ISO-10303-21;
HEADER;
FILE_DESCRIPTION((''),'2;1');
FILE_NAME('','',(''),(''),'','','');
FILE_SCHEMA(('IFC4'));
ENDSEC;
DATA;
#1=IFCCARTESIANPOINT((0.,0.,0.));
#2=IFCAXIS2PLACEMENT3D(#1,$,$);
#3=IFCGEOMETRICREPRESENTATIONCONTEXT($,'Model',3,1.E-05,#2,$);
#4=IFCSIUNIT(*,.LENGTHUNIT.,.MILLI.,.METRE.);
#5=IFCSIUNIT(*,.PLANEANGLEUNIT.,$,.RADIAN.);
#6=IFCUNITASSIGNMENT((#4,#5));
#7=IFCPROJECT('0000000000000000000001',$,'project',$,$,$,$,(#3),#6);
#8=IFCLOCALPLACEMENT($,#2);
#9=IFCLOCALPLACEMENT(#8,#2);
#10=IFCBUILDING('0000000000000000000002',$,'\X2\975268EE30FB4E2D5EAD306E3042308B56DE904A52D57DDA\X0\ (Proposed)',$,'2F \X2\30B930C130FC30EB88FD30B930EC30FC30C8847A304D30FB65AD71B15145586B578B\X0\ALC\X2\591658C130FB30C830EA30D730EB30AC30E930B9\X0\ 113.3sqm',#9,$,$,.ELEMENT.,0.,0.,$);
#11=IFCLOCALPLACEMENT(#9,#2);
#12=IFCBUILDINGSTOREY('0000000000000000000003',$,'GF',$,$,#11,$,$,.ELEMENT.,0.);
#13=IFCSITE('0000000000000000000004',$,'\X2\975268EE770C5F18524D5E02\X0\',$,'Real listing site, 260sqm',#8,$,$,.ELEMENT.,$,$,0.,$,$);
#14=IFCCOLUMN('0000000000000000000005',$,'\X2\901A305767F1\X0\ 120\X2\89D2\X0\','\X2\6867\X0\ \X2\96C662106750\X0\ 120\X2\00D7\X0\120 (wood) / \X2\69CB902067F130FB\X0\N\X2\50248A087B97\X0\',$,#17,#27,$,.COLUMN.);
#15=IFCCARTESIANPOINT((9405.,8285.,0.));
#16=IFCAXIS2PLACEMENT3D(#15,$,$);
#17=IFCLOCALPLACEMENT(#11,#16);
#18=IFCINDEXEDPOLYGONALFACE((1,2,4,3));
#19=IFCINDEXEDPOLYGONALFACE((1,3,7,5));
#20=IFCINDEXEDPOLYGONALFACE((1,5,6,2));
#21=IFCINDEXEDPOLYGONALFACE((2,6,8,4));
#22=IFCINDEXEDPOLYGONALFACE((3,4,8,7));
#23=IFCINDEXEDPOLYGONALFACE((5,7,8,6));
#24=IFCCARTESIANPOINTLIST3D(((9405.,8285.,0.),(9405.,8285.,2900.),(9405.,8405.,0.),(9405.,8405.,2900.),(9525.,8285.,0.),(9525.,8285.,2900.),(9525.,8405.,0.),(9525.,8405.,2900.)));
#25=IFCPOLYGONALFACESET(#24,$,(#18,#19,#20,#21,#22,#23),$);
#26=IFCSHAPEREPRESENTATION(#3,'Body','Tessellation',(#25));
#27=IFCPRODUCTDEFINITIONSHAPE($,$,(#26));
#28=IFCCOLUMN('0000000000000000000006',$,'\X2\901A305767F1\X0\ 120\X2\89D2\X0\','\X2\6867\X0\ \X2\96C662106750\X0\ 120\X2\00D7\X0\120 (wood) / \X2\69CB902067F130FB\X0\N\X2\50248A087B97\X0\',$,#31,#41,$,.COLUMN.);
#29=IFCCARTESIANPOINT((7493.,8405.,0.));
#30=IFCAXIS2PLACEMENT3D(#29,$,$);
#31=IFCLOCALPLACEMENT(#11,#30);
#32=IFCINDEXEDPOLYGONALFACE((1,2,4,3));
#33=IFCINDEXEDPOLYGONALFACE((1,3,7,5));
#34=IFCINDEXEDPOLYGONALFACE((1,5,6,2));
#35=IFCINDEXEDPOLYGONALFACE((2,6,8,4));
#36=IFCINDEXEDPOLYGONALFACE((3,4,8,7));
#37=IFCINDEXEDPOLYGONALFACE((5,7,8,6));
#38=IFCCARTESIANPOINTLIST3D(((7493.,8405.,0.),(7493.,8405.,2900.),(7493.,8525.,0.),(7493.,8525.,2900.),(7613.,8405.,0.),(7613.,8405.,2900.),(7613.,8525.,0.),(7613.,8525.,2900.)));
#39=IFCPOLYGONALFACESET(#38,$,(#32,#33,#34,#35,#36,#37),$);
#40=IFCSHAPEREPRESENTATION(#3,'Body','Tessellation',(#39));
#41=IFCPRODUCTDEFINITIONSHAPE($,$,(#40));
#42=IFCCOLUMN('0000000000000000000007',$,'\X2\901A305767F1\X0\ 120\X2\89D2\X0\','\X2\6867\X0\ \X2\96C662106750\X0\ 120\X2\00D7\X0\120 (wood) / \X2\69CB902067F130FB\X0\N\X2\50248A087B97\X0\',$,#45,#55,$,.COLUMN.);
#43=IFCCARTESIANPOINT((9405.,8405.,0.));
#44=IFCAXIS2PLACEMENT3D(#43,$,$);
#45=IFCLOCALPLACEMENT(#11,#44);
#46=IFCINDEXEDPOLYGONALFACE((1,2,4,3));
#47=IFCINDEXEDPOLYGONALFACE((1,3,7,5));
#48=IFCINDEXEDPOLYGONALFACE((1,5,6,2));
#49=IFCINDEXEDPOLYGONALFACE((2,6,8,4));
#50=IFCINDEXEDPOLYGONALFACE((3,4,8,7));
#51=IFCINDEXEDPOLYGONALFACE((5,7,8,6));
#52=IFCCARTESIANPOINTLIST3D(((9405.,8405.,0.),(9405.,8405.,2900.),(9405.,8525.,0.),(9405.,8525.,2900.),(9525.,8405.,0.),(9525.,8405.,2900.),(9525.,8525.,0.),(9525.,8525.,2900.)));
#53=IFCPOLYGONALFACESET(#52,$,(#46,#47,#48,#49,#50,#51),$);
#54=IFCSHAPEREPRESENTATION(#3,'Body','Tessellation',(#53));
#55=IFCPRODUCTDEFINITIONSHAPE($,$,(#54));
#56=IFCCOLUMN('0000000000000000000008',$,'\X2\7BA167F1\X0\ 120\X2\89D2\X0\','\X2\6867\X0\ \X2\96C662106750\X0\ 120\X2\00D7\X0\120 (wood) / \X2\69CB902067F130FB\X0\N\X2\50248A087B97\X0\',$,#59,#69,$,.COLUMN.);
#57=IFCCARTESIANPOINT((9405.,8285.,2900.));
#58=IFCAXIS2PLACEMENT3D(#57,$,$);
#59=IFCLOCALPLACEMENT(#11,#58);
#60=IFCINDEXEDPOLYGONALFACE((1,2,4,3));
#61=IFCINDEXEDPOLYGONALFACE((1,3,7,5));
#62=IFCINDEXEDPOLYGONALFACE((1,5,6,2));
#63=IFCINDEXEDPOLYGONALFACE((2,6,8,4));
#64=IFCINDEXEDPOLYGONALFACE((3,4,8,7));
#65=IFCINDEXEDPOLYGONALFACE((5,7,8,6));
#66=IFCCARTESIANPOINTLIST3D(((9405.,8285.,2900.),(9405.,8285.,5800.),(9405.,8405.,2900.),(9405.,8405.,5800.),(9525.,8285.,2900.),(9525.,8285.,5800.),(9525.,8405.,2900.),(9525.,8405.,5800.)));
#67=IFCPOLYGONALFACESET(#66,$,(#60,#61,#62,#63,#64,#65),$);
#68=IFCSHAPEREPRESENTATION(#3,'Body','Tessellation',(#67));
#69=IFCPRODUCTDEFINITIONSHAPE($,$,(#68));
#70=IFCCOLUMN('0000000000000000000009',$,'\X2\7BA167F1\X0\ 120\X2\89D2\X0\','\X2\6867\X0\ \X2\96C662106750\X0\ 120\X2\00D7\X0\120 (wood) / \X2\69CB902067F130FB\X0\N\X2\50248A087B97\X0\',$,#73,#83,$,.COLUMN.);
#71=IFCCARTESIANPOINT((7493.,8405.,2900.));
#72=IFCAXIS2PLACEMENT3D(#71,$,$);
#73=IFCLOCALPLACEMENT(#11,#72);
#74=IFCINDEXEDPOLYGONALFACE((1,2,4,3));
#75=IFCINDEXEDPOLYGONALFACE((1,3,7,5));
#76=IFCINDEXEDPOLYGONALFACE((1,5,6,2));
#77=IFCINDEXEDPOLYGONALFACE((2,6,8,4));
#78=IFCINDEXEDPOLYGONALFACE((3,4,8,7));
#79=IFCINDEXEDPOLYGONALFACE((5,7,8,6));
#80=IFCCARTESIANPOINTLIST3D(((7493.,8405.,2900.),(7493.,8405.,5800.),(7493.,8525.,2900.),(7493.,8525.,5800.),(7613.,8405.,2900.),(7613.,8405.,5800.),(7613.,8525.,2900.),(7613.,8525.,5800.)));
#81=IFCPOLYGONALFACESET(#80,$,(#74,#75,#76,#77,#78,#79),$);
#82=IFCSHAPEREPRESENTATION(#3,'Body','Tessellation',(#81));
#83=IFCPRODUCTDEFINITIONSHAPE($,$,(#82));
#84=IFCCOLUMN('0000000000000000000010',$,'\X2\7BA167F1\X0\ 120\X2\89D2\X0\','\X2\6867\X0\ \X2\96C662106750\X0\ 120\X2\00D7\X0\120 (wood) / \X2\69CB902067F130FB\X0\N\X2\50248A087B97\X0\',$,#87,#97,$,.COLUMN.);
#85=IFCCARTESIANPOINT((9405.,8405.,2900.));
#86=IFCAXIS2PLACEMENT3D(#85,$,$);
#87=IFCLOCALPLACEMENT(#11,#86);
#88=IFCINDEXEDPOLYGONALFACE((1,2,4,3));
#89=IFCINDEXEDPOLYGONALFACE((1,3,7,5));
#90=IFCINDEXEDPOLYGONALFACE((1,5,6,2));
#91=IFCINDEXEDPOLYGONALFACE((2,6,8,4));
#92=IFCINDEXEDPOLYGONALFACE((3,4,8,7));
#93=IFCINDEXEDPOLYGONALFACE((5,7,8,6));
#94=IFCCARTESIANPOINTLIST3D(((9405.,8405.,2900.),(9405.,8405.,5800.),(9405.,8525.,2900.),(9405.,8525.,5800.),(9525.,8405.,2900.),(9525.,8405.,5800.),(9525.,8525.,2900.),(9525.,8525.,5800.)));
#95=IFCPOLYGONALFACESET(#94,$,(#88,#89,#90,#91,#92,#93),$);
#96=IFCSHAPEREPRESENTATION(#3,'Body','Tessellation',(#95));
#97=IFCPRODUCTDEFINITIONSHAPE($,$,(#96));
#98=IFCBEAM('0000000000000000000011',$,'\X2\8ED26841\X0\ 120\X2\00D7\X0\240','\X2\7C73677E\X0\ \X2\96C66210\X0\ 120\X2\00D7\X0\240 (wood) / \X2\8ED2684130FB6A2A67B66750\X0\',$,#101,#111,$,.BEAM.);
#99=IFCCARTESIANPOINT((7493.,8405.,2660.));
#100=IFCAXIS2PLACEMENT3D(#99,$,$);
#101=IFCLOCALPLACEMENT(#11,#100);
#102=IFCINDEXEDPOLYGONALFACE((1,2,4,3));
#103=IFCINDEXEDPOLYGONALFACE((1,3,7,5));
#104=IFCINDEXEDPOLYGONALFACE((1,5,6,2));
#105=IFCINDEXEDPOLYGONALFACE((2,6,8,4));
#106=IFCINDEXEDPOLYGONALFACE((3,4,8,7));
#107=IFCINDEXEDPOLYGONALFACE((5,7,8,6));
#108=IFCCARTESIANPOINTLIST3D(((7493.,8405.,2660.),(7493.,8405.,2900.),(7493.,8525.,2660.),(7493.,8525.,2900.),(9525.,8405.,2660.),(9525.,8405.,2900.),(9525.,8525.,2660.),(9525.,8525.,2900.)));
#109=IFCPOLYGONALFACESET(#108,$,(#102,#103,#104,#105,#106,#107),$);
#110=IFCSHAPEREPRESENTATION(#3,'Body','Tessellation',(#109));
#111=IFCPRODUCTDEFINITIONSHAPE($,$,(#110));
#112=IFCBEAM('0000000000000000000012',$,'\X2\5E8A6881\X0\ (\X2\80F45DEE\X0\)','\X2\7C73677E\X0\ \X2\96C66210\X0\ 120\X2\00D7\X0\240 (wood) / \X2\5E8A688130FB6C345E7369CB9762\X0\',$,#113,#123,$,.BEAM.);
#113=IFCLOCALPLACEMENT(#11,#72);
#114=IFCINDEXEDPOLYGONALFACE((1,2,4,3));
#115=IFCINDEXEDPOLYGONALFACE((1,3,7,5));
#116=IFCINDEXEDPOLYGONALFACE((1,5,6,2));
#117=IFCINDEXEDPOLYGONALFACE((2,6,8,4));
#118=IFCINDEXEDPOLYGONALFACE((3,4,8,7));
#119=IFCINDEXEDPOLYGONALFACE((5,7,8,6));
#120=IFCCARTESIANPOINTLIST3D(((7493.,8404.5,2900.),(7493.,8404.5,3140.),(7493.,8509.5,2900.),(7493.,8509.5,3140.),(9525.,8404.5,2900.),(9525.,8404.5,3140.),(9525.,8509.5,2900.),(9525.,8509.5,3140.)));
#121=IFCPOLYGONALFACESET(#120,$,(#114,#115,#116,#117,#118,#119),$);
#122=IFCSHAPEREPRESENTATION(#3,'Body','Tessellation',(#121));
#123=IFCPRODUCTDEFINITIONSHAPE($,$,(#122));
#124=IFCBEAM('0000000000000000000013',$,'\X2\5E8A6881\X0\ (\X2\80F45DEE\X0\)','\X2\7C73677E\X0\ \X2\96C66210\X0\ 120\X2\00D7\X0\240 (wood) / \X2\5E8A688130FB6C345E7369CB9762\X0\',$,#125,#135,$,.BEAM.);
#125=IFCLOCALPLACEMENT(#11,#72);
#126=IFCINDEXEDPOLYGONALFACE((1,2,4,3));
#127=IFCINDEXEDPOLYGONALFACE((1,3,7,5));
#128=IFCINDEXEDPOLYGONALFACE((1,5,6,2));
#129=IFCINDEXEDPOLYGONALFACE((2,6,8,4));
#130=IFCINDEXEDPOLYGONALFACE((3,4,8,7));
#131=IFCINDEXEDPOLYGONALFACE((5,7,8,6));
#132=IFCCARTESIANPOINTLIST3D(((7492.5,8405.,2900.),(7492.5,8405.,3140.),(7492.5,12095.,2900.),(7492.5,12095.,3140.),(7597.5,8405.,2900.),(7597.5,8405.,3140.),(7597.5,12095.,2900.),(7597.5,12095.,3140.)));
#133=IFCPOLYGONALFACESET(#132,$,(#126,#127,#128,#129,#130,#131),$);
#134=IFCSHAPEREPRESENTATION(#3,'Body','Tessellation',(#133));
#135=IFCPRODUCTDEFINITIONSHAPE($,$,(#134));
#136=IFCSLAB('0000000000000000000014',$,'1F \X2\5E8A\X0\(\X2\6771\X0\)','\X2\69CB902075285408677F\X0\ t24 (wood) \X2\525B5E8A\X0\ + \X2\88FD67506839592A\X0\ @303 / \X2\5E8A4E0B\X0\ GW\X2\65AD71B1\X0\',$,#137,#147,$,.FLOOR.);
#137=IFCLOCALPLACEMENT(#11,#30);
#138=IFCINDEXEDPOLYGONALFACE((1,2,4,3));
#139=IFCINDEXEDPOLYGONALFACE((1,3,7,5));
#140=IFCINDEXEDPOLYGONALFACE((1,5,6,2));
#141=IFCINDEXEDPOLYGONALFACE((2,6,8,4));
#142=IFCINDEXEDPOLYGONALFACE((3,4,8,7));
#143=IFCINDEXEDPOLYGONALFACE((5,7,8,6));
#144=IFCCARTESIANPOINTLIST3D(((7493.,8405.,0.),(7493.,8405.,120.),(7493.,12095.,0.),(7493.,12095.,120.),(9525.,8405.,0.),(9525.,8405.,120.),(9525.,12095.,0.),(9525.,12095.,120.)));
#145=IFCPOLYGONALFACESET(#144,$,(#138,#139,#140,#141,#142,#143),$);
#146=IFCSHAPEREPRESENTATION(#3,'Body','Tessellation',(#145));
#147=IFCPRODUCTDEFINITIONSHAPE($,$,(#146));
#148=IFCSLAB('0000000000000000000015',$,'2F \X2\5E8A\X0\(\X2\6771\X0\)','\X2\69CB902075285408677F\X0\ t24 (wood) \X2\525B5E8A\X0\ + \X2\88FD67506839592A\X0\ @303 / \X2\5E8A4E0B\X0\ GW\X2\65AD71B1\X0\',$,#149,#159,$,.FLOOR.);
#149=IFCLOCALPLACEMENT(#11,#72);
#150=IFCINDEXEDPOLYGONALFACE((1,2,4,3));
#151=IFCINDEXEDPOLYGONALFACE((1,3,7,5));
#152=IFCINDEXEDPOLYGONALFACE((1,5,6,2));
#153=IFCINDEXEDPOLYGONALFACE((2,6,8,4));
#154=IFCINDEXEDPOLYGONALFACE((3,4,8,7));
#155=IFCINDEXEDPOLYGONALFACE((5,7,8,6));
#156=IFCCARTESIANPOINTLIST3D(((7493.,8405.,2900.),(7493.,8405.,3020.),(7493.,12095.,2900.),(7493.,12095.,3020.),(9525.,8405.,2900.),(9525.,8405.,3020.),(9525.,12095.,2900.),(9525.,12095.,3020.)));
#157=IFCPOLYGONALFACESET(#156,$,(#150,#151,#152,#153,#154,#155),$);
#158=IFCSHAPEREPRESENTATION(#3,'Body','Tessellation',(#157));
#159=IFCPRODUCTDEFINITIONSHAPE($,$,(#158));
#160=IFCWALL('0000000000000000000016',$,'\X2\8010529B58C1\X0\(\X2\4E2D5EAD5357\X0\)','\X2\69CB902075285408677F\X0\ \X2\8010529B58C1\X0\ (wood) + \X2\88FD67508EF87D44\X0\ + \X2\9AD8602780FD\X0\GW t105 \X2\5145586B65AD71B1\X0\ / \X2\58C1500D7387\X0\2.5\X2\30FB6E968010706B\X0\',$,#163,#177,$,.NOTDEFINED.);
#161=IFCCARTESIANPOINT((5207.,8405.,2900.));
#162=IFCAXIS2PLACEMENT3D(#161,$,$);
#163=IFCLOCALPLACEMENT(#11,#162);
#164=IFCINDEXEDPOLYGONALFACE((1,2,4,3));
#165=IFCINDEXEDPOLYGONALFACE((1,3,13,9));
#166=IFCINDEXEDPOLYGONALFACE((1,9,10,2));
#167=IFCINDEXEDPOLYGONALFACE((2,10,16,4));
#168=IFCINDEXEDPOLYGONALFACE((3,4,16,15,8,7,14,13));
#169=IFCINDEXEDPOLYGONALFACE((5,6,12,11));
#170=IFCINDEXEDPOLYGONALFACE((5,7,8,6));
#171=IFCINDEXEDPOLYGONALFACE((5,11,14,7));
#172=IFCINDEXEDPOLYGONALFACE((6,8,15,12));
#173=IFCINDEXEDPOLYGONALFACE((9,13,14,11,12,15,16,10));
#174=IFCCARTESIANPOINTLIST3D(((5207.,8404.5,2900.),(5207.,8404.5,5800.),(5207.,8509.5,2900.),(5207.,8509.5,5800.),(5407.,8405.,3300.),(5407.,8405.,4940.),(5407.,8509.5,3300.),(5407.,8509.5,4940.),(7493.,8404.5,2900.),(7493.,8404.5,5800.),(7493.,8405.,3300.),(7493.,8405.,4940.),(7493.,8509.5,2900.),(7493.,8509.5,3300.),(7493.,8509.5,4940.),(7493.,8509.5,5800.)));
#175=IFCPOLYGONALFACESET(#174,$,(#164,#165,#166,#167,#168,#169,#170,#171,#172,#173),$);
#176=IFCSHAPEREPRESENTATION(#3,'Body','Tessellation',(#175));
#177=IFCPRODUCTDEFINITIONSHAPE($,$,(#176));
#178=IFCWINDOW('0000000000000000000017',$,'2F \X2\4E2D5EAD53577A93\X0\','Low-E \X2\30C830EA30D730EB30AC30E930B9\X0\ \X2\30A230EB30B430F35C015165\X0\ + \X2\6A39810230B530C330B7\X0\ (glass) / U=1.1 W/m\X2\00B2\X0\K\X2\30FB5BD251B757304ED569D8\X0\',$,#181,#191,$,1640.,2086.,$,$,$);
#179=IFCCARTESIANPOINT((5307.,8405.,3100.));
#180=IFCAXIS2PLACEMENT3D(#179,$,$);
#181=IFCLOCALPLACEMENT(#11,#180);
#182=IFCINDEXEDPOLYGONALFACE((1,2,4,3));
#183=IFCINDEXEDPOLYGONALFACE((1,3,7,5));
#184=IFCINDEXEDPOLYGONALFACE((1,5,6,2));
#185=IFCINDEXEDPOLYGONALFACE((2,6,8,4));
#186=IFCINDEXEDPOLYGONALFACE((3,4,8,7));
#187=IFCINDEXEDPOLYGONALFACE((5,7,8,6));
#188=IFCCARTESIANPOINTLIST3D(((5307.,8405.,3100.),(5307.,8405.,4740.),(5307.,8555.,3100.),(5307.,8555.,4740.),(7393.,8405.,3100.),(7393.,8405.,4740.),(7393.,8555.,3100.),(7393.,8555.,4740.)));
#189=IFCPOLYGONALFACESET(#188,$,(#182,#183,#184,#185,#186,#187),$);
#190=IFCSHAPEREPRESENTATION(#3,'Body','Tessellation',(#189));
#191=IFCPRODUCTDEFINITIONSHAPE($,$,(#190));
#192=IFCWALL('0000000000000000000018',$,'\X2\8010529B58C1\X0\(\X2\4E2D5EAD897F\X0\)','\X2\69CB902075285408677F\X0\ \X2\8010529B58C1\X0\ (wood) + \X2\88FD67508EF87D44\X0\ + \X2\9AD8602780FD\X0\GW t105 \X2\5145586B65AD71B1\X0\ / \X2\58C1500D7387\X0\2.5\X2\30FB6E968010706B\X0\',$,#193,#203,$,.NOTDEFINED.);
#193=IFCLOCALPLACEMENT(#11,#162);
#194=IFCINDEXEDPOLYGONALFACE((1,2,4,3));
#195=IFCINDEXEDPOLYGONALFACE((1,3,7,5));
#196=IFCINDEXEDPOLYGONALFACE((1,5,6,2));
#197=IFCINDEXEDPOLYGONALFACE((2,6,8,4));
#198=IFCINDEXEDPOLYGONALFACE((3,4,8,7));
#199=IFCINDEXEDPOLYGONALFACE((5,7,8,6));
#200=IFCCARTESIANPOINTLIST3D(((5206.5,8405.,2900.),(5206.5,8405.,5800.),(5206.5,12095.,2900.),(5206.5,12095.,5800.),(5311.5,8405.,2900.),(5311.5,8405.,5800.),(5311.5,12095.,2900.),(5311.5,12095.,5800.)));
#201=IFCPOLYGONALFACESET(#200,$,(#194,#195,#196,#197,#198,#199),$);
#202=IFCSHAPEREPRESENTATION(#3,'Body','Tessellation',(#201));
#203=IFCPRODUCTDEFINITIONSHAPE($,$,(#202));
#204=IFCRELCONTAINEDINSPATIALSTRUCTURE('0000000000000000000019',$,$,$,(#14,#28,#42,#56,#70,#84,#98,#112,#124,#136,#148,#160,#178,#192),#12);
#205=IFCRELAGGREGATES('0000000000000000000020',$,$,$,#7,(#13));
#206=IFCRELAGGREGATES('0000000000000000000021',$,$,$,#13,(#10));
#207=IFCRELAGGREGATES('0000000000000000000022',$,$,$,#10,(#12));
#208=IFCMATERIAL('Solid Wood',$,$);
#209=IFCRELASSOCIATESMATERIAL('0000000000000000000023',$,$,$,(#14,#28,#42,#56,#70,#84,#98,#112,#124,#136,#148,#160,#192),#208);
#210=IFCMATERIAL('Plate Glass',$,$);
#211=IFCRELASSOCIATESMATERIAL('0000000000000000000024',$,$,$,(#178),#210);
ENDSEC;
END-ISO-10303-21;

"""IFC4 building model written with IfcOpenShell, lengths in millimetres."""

from ifc_helpers import new_model, si_unit, frame, frame_2d, origin, place, context, project, spatial, rectangle, extrude, material, element, fill, save


model = new_model("IFC4")

# Units and contexts
model_context = context("Model", 3, precision=1e-05, world=origin())
ifc_project = project(units=[si_unit("LENGTHUNIT", "METRE", prefix="MILLI"), si_unit("PLANEANGLEUNIT", "RADIAN")], contexts=[model_context])

# Site, building, storey
site_placement = place(None, origin())
site = spatial("IfcSite", under=ifc_project, at=site_placement, Name="青森県弘前市", ObjectType="Real listing site, 260sqm", CompositionType="ELEMENT", RefElevation=0.0)
building_placement = place(site_placement, origin())
building = spatial("IfcBuilding", under=site, at=building_placement, Name="青森・中庭のある回遊動線 (Proposed)", ObjectType="2F スチール製スレート葺き・断熱充填型ALC外壁・トリプルガラス 113.3sqm", CompositionType="ELEMENT", ElevationOfRefHeight=0.0, ElevationOfTerrain=0.0)
storey_placement = place(building_placement, origin())
storey = spatial("IfcBuildingStorey", under=building, at=storey_placement, Name="GF", CompositionType="ELEMENT", Elevation=0.0)

# Columns
ifc_material_1 = material(Name="Solid Wood")
column_1_placement = place(storey_placement, frame((9405.0, 8285.0, 0.0)))
element("IfcColumn", 1, at=column_1_placement, inside=storey, material=ifc_material_1, Name="通し柱 120角", Description="桧 集成材 120×120 (wood) / 構造柱・N値計算", PredefinedType="COLUMN", context=model_context, shape_type="SweptSolid", body=[
    extrude(rectangle(XDim=120.0, YDim=120.0, at=frame_2d((60.0, 60.0))), frame((9405.0, 8285.0, 0.0)), (0.0, 0.0, 1.0), 2900.0),
])
column_2_placement = place(storey_placement, frame((7493.0, 8405.0, 0.0)))
element("IfcColumn", 2, at=column_2_placement, inside=storey, material=ifc_material_1, Name="通し柱 120角", Description="桧 集成材 120×120 (wood) / 構造柱・N値計算", PredefinedType="COLUMN", context=model_context, shape_type="SweptSolid", body=[
    extrude(rectangle(XDim=120.0, YDim=120.0, at=frame_2d((60.0, 60.0))), frame((7493.0, 8405.0, 0.0)), (0.0, 0.0, 1.0), 2900.0),
])
column_3_placement = place(storey_placement, frame((9405.0, 8405.0, 0.0)))
element("IfcColumn", 3, at=column_3_placement, inside=storey, material=ifc_material_1, Name="通し柱 120角", Description="桧 集成材 120×120 (wood) / 構造柱・N値計算", PredefinedType="COLUMN", context=model_context, shape_type="SweptSolid", body=[
    extrude(rectangle(XDim=120.0, YDim=120.0, at=frame_2d((60.0, 60.0))), frame((9405.0, 8405.0, 0.0)), (0.0, 0.0, 1.0), 2900.0),
])
column_4_placement = place(storey_placement, frame((9405.0, 8285.0, 2900.0)))
element("IfcColumn", 4, at=column_4_placement, inside=storey, material=ifc_material_1, Name="管柱 120角", Description="桧 集成材 120×120 (wood) / 構造柱・N値計算", PredefinedType="COLUMN", context=model_context, shape_type="SweptSolid", body=[
    extrude(rectangle(XDim=120.0, YDim=120.0, at=frame_2d((60.0, 60.0))), frame((9405.0, 8285.0, 2900.0)), (0.0, 0.0, 1.0), 2900.0),
])
column_5_placement = place(storey_placement, frame((7493.0, 8405.0, 2900.0)))
element("IfcColumn", 5, at=column_5_placement, inside=storey, material=ifc_material_1, Name="管柱 120角", Description="桧 集成材 120×120 (wood) / 構造柱・N値計算", PredefinedType="COLUMN", context=model_context, shape_type="SweptSolid", body=[
    extrude(rectangle(XDim=120.0, YDim=120.0, at=frame_2d((60.0, 60.0))), frame((7493.0, 8405.0, 2900.0)), (0.0, 0.0, 1.0), 2900.0),
])
column_6_placement = place(storey_placement, frame((9405.0, 8405.0, 2900.0)))
element("IfcColumn", 6, at=column_6_placement, inside=storey, material=ifc_material_1, Name="管柱 120角", Description="桧 集成材 120×120 (wood) / 構造柱・N値計算", PredefinedType="COLUMN", context=model_context, shape_type="SweptSolid", body=[
    extrude(rectangle(XDim=120.0, YDim=120.0, at=frame_2d((60.0, 60.0))), frame((9405.0, 8405.0, 2900.0)), (0.0, 0.0, 1.0), 2900.0),
])

# Beams
beam_1_placement = place(storey_placement, frame((7493.0, 8405.0, 2660.0)))
element("IfcBeam", 7, at=beam_1_placement, inside=storey, material=ifc_material_1, Name="軒桁 120×240", Description="米松 集成 120×240 (wood) / 軒桁・横架材", PredefinedType="BEAM", context=model_context, shape_type="SweptSolid", body=[
    extrude(rectangle(XDim=2032.0, YDim=120.0, at=frame_2d((1016.0, 60.0))), frame((7493.0, 8405.0, 2660.0)), (0.0, 0.0, 1.0), 240.0),
])
beam_2_placement = place(storey_placement, frame((7493.0, 8405.0, 2900.0)))
element("IfcBeam", 8, at=beam_2_placement, inside=storey, material=ifc_material_1, Name="床梁 (胴差)", Description="米松 集成 120×240 (wood) / 床梁・水平構面", PredefinedType="BEAM", context=model_context, shape_type="SweptSolid", body=[
    extrude(rectangle(XDim=2032.0, YDim=105.0, at=frame_2d((1016.0, 52.0))), frame((7493.0, 8405.0, 2900.0)), (0.0, 0.0, 1.0), 240.0),
])
beam_3_placement = place(storey_placement, frame((7493.0, 8405.0, 2900.0)))
element("IfcBeam", 9, at=beam_3_placement, inside=storey, material=ifc_material_1, Name="床梁 (胴差)", Description="米松 集成 120×240 (wood) / 床梁・水平構面", PredefinedType="BEAM", context=model_context, shape_type="SweptSolid", body=[
    extrude(rectangle(XDim=105.0, YDim=3690.0, at=frame_2d((52.0, 1845.0))), frame((7493.0, 8405.0, 2900.0)), (0.0, 0.0, 1.0), 240.0),
])

# Slabs
slab_1_placement = place(storey_placement, frame((7493.0, 8405.0, 0.0)))
element("IfcSlab", 10, at=slab_1_placement, inside=storey, material=ifc_material_1, Name="1F 床(東)", Description="構造用合板 t24 (wood) 剛床 + 製材根太 @303 / 床下 GW断熱", PredefinedType="FLOOR", context=model_context, shape_type="SweptSolid", body=[
    extrude(rectangle(XDim=2032.0, YDim=3690.0, at=frame_2d((1016.0, 1845.0))), frame((7493.0, 8405.0, 0.0)), (0.0, 0.0, 1.0), 120.0),
])
slab_2_placement = place(storey_placement, frame((7493.0, 8405.0, 2900.0)))
element("IfcSlab", 11, at=slab_2_placement, inside=storey, material=ifc_material_1, Name="2F 床(東)", Description="構造用合板 t24 (wood) 剛床 + 製材根太 @303 / 床下 GW断熱", PredefinedType="FLOOR", context=model_context, shape_type="SweptSolid", body=[
    extrude(rectangle(XDim=2032.0, YDim=3690.0, at=frame_2d((1016.0, 1845.0))), frame((7493.0, 8405.0, 2900.0)), (0.0, 0.0, 1.0), 120.0),
])

# Wall, opening, window
wall_1_placement = place(storey_placement, frame((5207.0, 8405.0, 2900.0)))
wall_1 = element("IfcWall", 12, at=wall_1_placement, inside=storey, material=ifc_material_1, Name="耐力壁(中庭南)", Description="構造用合板 耐力壁 (wood) + 製材軸組 + 高性能GW t105 充填断熱 / 壁倍率2.5・準耐火", PredefinedType="NOTDEFINED", context=model_context, shape_type="SweptSolid", body=[
    extrude(rectangle(XDim=2286.0, YDim=105.0, at=frame_2d((1143.0, 52.0))), frame((5207.0, 8405.0, 2900.0)), (0.0, 0.0, 1.0), 2900.0),
])
opening_placement = place(storey_placement, frame((5307.0, 8405.0, 3100.0)))
opening = element("IfcOpeningElement", 13, at=opening_placement, cuts=wall_1, PredefinedType="NOTDEFINED", context=model_context, shape_type="SweptSolid", body=[
    extrude(rectangle(XDim=2086.0, YDim=150.0, at=frame_2d((1043.0, 75.0))), frame((5307.0, 8405.0, 3100.0)), (0.0, 0.0, 1.0), 1640.0),
])
ifc_material_2 = material(Name="Plate Glass")
window_placement = place(storey_placement, frame((5307.0, 8405.0, 3100.0)))
window = element("IfcWindow", 14, at=window_placement, inside=storey, material=ifc_material_2, Name="2F 中庭南窓", Description="Low-E トリプルガラス アルゴン封入 + 樹脂サッシ (glass) / U=1.1 W/m²K・寒冷地仕様", OverallHeight=1640.0, OverallWidth=2086.0, context=model_context, shape_type="SweptSolid", body=[
    extrude(rectangle(XDim=2086.0, YDim=150.0, at=frame_2d((1043.0, 75.0))), frame((5307.0, 8405.0, 3100.0)), (0.0, 0.0, 1.0), 1640.0),
])
fill(opening, window)

# Wall
wall_2_placement = place(storey_placement, frame((5207.0, 8405.0, 2900.0)))
element("IfcWall", 15, at=wall_2_placement, inside=storey, material=ifc_material_1, Name="耐力壁(中庭西)", Description="構造用合板 耐力壁 (wood) + 製材軸組 + 高性能GW t105 充填断熱 / 壁倍率2.5・準耐火", PredefinedType="NOTDEFINED", context=model_context, shape_type="SweptSolid", body=[
    extrude(rectangle(XDim=105.0, YDim=3690.0, at=frame_2d((52.0, 1845.0))), frame((5207.0, 8405.0, 2900.0)), (0.0, 0.0, 1.0), 2900.0),
])

save(model, "model.ifc")
